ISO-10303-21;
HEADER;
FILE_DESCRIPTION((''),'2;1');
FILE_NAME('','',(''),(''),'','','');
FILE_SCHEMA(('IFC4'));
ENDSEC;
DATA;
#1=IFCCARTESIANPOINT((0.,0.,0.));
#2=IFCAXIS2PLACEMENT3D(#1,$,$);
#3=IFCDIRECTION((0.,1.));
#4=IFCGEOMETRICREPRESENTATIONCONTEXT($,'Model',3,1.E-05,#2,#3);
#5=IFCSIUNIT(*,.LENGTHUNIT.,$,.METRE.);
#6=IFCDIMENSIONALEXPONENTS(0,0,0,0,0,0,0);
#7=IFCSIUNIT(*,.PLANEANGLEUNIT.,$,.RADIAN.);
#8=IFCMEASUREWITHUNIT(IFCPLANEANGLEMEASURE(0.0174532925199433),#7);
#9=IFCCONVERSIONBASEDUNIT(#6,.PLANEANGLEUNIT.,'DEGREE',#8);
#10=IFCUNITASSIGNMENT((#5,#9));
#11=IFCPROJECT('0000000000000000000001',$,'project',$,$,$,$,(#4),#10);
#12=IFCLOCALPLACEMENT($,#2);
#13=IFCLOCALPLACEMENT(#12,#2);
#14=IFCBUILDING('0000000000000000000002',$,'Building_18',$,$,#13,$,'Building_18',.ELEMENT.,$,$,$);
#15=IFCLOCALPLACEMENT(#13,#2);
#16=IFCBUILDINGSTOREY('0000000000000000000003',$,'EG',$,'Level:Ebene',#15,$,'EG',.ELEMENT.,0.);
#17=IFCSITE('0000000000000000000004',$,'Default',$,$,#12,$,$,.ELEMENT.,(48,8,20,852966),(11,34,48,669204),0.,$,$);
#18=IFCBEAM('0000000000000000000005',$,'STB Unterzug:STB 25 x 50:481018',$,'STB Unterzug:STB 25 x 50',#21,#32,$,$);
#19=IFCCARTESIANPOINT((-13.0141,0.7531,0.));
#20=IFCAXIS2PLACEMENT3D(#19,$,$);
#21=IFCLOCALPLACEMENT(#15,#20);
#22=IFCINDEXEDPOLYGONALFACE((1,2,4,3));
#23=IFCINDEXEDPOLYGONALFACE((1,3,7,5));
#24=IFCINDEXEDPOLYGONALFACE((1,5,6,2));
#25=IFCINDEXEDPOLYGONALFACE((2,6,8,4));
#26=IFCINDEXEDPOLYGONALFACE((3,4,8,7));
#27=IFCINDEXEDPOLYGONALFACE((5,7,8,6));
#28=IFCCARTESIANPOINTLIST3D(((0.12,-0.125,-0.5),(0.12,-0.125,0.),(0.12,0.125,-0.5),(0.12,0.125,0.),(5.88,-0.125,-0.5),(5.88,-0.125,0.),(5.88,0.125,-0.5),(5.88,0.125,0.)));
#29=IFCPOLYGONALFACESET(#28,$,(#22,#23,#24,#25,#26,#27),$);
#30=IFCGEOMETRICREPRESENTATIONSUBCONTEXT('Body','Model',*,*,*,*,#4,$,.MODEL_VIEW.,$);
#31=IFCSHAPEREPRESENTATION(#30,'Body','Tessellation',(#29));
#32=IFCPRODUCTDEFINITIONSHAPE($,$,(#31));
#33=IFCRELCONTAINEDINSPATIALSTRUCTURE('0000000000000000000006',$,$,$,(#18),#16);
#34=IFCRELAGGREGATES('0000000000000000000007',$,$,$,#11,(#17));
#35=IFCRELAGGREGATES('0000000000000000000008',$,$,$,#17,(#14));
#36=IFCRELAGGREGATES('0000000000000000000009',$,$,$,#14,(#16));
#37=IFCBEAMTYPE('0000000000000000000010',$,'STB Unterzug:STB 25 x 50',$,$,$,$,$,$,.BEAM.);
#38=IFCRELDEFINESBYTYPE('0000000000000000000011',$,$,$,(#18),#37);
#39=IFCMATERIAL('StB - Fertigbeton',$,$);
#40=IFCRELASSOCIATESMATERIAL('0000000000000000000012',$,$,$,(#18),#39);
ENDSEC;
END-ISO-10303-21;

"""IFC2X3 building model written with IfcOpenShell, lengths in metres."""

from ifc_helpers import new_model, entity, si_unit, converted_unit, direction, frame, frame_2d, origin, place, context, subcontext, project, spatial, rectangle, extrude, material, type_object, element, save


model = new_model("IFC2X3")

# Units and contexts
model_context = context("Model", 3, precision=1e-05, world=origin(), true_north=direction((0.0, 1.0)))
body_context = subcontext(model_context, "Body", "Model", "MODEL_VIEW")
ifc_project = project(units=[si_unit("LENGTHUNIT", "METRE"), converted_unit("PLANEANGLEUNIT", "DEGREE", entity("IfcPlaneAngleMeasure", 0.0174532925199433), si_unit("PLANEANGLEUNIT", "RADIAN"), dimensions=[0, 0, 0, 0, 0, 0, 0])], contexts=[model_context])

# Site, building, storey
site_placement = place(None, origin())
site = spatial("IfcSite", under=ifc_project, at=site_placement, Name="Default", CompositionType="ELEMENT", RefLatitude=(48, 8, 20, 852966), RefLongitude=(11, 34, 48, 669204), RefElevation=0.0)
building_placement = place(site_placement, origin())
building = spatial("IfcBuilding", under=site, at=building_placement, Name="Building_18", LongName="Building_18", CompositionType="ELEMENT")
storey_placement = place(building_placement, origin())
storey = spatial("IfcBuildingStorey", under=building, at=storey_placement, Name="EG", ObjectType="Level:Ebene", LongName="EG", CompositionType="ELEMENT", Elevation=0.0)

# Beam
ifc_material_1 = material(Name="StB - Fertigbeton")
beam_type = type_object("IfcBeamType", Name="STB Unterzug:STB 25 x 50", PredefinedType="BEAM")
beam_placement = place(storey_placement, frame((-13.0141, 0.7531, 0.0)))
element("IfcBeam", 1, at=beam_placement, inside=storey, type_object=beam_type, material=ifc_material_1, Name="STB Unterzug:STB 25 x 50:481018", ObjectType="STB Unterzug:STB 25 x 50", context=body_context, shape_type="SweptSolid", body=[
    extrude(rectangle(XDim=0.5, YDim=0.25, at=frame_2d((0.0, 0.0), x_axis=(1.0, 0.0))), frame((0.12, 0.0, -0.25), z_axis=(1.0, 0.0, 0.0), x_axis=(0.0, 0.0, -1.0)), (0.0, 0.0, 1.0), 5.76),
])

save(model, "model.ifc")
